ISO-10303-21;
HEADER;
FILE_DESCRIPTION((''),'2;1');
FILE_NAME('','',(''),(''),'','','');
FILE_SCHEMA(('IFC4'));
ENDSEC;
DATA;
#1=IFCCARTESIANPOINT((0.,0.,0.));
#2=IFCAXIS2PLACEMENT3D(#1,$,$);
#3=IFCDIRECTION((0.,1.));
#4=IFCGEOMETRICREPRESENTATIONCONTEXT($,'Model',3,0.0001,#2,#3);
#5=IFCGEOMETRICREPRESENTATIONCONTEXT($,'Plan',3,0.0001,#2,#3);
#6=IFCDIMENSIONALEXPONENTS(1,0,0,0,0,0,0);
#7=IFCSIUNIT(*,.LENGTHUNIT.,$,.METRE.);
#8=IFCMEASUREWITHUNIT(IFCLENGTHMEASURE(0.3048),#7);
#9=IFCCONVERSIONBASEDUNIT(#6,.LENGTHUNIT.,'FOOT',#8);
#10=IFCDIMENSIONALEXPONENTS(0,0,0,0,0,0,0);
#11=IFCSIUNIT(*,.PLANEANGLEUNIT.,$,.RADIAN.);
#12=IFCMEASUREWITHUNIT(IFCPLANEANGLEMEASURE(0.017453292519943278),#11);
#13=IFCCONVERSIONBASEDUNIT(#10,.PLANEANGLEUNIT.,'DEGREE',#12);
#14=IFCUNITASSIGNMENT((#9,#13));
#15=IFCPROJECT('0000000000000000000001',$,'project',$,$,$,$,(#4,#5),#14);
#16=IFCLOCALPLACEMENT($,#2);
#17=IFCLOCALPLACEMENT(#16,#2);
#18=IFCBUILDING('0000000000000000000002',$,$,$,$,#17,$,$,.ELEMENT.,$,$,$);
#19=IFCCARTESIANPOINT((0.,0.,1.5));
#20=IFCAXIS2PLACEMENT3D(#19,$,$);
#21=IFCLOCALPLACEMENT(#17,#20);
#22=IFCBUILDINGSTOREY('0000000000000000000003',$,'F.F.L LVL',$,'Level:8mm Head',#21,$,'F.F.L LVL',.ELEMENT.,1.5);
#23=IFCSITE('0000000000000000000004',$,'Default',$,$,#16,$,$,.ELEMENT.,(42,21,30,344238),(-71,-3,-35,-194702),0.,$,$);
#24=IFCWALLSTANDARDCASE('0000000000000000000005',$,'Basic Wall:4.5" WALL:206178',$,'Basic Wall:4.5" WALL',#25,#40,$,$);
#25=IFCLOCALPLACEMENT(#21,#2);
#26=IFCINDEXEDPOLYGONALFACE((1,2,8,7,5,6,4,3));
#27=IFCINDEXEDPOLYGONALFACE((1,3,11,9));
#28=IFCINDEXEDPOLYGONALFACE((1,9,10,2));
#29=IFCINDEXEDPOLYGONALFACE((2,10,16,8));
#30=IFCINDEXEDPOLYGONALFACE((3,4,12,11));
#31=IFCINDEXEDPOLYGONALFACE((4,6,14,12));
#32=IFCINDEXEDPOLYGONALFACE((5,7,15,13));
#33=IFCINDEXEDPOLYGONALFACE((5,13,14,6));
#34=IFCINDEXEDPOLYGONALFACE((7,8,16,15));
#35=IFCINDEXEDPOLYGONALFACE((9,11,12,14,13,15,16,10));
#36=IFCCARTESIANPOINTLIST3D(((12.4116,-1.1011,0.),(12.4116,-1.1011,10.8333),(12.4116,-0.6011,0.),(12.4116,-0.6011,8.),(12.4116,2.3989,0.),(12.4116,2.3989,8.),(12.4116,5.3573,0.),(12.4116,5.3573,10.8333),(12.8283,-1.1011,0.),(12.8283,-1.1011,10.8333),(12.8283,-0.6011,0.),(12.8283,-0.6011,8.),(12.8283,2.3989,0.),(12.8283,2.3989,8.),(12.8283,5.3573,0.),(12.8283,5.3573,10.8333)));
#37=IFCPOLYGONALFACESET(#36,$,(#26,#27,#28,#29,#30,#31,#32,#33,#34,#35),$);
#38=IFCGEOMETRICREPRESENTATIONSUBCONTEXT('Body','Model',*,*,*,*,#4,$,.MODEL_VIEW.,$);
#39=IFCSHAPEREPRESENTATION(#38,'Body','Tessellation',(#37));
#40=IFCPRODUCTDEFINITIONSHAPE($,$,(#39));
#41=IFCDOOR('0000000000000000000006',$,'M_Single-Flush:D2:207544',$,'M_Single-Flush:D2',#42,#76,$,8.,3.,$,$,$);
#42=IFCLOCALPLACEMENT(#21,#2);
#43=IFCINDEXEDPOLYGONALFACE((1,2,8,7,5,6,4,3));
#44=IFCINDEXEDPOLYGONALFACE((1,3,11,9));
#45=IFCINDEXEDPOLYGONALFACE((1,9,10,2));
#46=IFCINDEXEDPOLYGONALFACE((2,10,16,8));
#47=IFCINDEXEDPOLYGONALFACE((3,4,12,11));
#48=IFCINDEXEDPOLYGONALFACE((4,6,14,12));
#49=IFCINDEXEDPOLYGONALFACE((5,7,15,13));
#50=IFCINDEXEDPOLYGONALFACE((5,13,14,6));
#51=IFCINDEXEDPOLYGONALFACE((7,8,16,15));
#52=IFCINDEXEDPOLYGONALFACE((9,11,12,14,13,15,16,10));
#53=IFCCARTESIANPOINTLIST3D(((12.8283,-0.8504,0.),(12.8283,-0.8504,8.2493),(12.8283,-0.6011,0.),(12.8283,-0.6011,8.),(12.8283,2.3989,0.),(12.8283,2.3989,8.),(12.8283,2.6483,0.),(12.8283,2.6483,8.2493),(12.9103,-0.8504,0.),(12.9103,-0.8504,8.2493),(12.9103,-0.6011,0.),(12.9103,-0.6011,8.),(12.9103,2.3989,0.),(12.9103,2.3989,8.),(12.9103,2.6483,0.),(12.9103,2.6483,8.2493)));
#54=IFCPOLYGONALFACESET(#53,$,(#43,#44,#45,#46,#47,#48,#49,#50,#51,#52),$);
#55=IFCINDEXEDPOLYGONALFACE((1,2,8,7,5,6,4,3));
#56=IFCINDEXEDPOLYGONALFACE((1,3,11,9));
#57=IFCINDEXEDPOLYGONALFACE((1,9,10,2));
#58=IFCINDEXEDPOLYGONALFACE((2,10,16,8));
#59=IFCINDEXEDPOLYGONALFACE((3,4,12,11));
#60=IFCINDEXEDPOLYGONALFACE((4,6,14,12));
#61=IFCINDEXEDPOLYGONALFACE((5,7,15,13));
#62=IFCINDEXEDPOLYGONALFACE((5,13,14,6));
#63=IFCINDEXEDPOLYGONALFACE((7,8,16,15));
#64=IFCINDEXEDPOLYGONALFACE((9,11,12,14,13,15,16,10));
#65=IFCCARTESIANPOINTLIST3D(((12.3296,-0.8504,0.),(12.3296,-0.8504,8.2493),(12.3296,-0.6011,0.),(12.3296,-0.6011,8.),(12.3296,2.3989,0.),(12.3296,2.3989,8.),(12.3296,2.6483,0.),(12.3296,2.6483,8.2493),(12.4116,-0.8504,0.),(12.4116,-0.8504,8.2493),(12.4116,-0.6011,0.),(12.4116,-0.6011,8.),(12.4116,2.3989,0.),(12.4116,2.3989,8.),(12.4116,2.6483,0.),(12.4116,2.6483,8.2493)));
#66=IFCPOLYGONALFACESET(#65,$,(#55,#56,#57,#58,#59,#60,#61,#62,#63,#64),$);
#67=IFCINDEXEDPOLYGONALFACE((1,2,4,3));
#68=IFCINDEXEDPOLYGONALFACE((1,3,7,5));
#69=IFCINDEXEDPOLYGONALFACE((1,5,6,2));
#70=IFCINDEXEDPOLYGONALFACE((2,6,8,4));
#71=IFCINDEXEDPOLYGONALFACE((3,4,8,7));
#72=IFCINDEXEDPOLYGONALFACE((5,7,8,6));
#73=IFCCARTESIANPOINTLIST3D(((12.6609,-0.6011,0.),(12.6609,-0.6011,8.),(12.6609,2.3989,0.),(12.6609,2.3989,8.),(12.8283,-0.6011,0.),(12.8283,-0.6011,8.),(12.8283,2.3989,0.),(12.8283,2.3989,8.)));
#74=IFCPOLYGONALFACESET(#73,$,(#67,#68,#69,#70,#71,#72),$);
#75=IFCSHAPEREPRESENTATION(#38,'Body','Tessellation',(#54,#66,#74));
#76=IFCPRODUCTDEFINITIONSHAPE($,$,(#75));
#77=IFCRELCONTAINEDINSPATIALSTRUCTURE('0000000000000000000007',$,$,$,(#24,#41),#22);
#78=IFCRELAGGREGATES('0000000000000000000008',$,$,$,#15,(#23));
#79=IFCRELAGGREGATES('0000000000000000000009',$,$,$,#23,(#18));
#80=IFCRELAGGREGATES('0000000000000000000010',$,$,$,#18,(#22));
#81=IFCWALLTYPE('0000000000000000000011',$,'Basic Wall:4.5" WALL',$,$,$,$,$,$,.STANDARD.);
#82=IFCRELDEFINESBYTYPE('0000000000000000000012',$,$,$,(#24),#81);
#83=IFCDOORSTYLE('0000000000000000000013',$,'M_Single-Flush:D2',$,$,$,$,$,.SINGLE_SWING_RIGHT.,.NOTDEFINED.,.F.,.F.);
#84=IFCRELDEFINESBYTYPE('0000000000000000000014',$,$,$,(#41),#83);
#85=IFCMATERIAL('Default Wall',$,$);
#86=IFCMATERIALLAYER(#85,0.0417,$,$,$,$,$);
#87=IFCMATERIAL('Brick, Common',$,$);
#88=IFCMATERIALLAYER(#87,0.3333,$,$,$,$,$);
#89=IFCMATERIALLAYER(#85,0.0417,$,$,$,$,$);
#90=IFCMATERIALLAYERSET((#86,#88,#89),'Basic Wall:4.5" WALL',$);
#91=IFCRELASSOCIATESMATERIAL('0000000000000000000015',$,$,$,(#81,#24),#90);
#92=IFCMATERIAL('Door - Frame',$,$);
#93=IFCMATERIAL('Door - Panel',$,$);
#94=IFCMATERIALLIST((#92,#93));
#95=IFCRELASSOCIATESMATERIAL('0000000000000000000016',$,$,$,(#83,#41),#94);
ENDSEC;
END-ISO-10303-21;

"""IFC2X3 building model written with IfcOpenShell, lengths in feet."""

from ifc_helpers import new_model, entity, si_unit, converted_unit, direction, frame, frame_2d, origin, place, context, subcontext, project, spatial, polyline, rectangle, outline, extrude, source, transform, mapped, material, material_list, layer, layer_set, layer_usage, type_object, type_shapes, element, fill, save


model = new_model("IFC2X3")

# Units and contexts
model_context = context("Model", 3, precision=0.0001, world=origin(), true_north=direction((0.0, 1.0)))
plan_context = context("Plan", 3, precision=0.0001, world=origin(), true_north=direction((0.0, 1.0)))
body_context = subcontext(model_context, "Body", "Model", "MODEL_VIEW")
ifc_project = project(units=[converted_unit("LENGTHUNIT", "FOOT", entity("IfcLengthMeasure", 0.3048), si_unit("LENGTHUNIT", "METRE"), dimensions=[1, 0, 0, 0, 0, 0, 0]), converted_unit("PLANEANGLEUNIT", "DEGREE", entity("IfcPlaneAngleMeasure", 0.017453292519943278), si_unit("PLANEANGLEUNIT", "RADIAN"), dimensions=[0, 0, 0, 0, 0, 0, 0])], contexts=[model_context, plan_context])

# Site, building, storey
site_placement = place(None, origin())
site = spatial("IfcSite", under=ifc_project, at=site_placement, Name="Default", CompositionType="ELEMENT", RefLatitude=(42, 21, 30, 344238), RefLongitude=(-71, -3, -35, -194702), RefElevation=0.0)
building_placement = place(site_placement, origin())
building = spatial("IfcBuilding", under=site, at=building_placement, CompositionType="ELEMENT")
storey_placement = place(building_placement, frame((0.0, 0.0, 1.5)))
storey = spatial("IfcBuildingStorey", under=building, at=storey_placement, Name="F.F.L LVL", ObjectType="Level:8mm Head", LongName="F.F.L LVL", CompositionType="ELEMENT", Elevation=1.5)

# Shared definitions
ifc_material_1 = material(Name="Default Wall")
ifc_material_2 = material(Name="Brick, Common")

# Shared definitions
ifc_material_3 = material(Name="Door - Panel")
ifc_material_4 = material(Name="Door - Frame")

# Shared definitions
ifc_layer_1 = layer(ifc_material_1, 0.0417)
ifc_layer_2 = layer(ifc_material_2, 0.3333)
ifc_layer_3 = layer(ifc_material_1, 0.0417)
ifc_layer_set_1 = layer_set([ifc_layer_1, ifc_layer_2, ifc_layer_3], Name="Basic Wall:4.5\" WALL")
wall_type_1 = type_object("IfcWallType", Name="Basic Wall:4.5\" WALL", PredefinedType="STANDARD", material=ifc_layer_set_1)
ifc_material_list_1 = material_list([ifc_material_4, ifc_material_3])

# Wall, opening, door
door_style_1 = type_object("IfcDoorStyle", Name="M_Single-Flush:D2", ConstructionType="NOTDEFINED", OperationType="SINGLE_SWING_RIGHT", ParameterTakesPrecedence=False, Sizeable=False, material=ifc_material_list_1)
shared_shape_1 = source(origin(), body_context, "Body", "SweptSolid", [
    extrude(outline(polyline([(-1.7493, -4.187), (1.7493, -4.187), (1.7493, 4.0623), (1.5, 4.0623), (1.5, -3.9377), (-1.5, -3.9377), (-1.5, 4.0623), (-1.7493, 4.0623), (-1.7493, -4.187)])), frame((1.5, 0.4167, 4.0623), z_axis=(0.0, 1.0, 0.0), x_axis=(1.0, 0.0, 0.0)), (0.0, 0.0, 1.0), 0.082),
    extrude(outline(polyline([(-4.187, -1.7493), (4.0623, -1.7493), (4.0623, -1.5), (-3.9377, -1.5), (-3.9377, 1.5), (4.0623, 1.5), (4.0623, 1.7493), (-4.187, 1.7493), (-4.187, -1.7493)])), frame((1.5, -0.082, 4.0623), z_axis=(0.0, 1.0, 0.0), x_axis=(0.0, 0.0, -1.0)), (0.0, 0.0, 1.0), 0.082),
    extrude(rectangle(XDim=0.1673, YDim=3.0, at=frame_2d((0.0, 0.0), x_axis=(1.0, 0.0))), frame((1.5, 0.333, 0.0), z_axis=(0.0, 0.0, 1.0), x_axis=(0.0, 1.0, 0.0)), (0.0, 0.0, 1.0), 8.0),
])
type_shapes(door_style_1, [shared_shape_1])
ifc_layer_usage_1 = layer_usage(ifc_layer_set_1, "AXIS2", "NEGATIVE", 0.2083)
wall_1_placement = place(storey_placement, frame((12.6199, 5.3573, 0.0), z_axis=(0.0, 0.0, 1.0), x_axis=(0.0, -1.0, 0.0)))
wall_1 = element("IfcWallStandardCase", 1, at=wall_1_placement, inside=storey, type_object=wall_type_1, material=ifc_layer_usage_1, Name="Basic Wall:4.5\" WALL:206178", ObjectType="Basic Wall:4.5\" WALL", context=body_context, shape_type="SweptSolid", body=[
    extrude(rectangle(XDim=6.4583, YDim=0.4167, at=frame_2d((3.2292, 0.0), x_axis=(-1.0, 0.0))), origin(), (0.0, 0.0, 1.0), 10.8333),
])
opening_1_placement = place(wall_1_placement, frame((2.9583, -0.2083, 0.0)))
opening_1 = element("IfcOpeningElement", 2, at=opening_1_placement, cuts=wall_1, ObjectType="Opening", context=body_context, shape_type="SweptSolid", body=[
    extrude(rectangle(XDim=3.0, YDim=8.0, at=frame_2d((4.0, 1.5), x_axis=(0.0, 1.0))), frame((0.0, 0.0, 0.0), z_axis=(0.0, 1.0, 0.0), x_axis=(0.0, 0.0, 1.0)), (0.0, 0.0, 1.0), 0.4167),
])
door_1_placement = place(opening_1_placement, origin())
door_1 = element("IfcDoor", 3, at=door_1_placement, inside=storey, type_object=door_style_1, material=ifc_material_list_1, Name="M_Single-Flush:D2:207544", ObjectType="M_Single-Flush:D2", OverallHeight=8.0, OverallWidth=3.0, context=body_context, shape_type="MappedRepresentation", body=[
    mapped(shared_shape_1, transform((0.0, 0.0, 0.0), scale=1.0)),
])
fill(opening_1, door_1)

save(model, "model.ifc")
